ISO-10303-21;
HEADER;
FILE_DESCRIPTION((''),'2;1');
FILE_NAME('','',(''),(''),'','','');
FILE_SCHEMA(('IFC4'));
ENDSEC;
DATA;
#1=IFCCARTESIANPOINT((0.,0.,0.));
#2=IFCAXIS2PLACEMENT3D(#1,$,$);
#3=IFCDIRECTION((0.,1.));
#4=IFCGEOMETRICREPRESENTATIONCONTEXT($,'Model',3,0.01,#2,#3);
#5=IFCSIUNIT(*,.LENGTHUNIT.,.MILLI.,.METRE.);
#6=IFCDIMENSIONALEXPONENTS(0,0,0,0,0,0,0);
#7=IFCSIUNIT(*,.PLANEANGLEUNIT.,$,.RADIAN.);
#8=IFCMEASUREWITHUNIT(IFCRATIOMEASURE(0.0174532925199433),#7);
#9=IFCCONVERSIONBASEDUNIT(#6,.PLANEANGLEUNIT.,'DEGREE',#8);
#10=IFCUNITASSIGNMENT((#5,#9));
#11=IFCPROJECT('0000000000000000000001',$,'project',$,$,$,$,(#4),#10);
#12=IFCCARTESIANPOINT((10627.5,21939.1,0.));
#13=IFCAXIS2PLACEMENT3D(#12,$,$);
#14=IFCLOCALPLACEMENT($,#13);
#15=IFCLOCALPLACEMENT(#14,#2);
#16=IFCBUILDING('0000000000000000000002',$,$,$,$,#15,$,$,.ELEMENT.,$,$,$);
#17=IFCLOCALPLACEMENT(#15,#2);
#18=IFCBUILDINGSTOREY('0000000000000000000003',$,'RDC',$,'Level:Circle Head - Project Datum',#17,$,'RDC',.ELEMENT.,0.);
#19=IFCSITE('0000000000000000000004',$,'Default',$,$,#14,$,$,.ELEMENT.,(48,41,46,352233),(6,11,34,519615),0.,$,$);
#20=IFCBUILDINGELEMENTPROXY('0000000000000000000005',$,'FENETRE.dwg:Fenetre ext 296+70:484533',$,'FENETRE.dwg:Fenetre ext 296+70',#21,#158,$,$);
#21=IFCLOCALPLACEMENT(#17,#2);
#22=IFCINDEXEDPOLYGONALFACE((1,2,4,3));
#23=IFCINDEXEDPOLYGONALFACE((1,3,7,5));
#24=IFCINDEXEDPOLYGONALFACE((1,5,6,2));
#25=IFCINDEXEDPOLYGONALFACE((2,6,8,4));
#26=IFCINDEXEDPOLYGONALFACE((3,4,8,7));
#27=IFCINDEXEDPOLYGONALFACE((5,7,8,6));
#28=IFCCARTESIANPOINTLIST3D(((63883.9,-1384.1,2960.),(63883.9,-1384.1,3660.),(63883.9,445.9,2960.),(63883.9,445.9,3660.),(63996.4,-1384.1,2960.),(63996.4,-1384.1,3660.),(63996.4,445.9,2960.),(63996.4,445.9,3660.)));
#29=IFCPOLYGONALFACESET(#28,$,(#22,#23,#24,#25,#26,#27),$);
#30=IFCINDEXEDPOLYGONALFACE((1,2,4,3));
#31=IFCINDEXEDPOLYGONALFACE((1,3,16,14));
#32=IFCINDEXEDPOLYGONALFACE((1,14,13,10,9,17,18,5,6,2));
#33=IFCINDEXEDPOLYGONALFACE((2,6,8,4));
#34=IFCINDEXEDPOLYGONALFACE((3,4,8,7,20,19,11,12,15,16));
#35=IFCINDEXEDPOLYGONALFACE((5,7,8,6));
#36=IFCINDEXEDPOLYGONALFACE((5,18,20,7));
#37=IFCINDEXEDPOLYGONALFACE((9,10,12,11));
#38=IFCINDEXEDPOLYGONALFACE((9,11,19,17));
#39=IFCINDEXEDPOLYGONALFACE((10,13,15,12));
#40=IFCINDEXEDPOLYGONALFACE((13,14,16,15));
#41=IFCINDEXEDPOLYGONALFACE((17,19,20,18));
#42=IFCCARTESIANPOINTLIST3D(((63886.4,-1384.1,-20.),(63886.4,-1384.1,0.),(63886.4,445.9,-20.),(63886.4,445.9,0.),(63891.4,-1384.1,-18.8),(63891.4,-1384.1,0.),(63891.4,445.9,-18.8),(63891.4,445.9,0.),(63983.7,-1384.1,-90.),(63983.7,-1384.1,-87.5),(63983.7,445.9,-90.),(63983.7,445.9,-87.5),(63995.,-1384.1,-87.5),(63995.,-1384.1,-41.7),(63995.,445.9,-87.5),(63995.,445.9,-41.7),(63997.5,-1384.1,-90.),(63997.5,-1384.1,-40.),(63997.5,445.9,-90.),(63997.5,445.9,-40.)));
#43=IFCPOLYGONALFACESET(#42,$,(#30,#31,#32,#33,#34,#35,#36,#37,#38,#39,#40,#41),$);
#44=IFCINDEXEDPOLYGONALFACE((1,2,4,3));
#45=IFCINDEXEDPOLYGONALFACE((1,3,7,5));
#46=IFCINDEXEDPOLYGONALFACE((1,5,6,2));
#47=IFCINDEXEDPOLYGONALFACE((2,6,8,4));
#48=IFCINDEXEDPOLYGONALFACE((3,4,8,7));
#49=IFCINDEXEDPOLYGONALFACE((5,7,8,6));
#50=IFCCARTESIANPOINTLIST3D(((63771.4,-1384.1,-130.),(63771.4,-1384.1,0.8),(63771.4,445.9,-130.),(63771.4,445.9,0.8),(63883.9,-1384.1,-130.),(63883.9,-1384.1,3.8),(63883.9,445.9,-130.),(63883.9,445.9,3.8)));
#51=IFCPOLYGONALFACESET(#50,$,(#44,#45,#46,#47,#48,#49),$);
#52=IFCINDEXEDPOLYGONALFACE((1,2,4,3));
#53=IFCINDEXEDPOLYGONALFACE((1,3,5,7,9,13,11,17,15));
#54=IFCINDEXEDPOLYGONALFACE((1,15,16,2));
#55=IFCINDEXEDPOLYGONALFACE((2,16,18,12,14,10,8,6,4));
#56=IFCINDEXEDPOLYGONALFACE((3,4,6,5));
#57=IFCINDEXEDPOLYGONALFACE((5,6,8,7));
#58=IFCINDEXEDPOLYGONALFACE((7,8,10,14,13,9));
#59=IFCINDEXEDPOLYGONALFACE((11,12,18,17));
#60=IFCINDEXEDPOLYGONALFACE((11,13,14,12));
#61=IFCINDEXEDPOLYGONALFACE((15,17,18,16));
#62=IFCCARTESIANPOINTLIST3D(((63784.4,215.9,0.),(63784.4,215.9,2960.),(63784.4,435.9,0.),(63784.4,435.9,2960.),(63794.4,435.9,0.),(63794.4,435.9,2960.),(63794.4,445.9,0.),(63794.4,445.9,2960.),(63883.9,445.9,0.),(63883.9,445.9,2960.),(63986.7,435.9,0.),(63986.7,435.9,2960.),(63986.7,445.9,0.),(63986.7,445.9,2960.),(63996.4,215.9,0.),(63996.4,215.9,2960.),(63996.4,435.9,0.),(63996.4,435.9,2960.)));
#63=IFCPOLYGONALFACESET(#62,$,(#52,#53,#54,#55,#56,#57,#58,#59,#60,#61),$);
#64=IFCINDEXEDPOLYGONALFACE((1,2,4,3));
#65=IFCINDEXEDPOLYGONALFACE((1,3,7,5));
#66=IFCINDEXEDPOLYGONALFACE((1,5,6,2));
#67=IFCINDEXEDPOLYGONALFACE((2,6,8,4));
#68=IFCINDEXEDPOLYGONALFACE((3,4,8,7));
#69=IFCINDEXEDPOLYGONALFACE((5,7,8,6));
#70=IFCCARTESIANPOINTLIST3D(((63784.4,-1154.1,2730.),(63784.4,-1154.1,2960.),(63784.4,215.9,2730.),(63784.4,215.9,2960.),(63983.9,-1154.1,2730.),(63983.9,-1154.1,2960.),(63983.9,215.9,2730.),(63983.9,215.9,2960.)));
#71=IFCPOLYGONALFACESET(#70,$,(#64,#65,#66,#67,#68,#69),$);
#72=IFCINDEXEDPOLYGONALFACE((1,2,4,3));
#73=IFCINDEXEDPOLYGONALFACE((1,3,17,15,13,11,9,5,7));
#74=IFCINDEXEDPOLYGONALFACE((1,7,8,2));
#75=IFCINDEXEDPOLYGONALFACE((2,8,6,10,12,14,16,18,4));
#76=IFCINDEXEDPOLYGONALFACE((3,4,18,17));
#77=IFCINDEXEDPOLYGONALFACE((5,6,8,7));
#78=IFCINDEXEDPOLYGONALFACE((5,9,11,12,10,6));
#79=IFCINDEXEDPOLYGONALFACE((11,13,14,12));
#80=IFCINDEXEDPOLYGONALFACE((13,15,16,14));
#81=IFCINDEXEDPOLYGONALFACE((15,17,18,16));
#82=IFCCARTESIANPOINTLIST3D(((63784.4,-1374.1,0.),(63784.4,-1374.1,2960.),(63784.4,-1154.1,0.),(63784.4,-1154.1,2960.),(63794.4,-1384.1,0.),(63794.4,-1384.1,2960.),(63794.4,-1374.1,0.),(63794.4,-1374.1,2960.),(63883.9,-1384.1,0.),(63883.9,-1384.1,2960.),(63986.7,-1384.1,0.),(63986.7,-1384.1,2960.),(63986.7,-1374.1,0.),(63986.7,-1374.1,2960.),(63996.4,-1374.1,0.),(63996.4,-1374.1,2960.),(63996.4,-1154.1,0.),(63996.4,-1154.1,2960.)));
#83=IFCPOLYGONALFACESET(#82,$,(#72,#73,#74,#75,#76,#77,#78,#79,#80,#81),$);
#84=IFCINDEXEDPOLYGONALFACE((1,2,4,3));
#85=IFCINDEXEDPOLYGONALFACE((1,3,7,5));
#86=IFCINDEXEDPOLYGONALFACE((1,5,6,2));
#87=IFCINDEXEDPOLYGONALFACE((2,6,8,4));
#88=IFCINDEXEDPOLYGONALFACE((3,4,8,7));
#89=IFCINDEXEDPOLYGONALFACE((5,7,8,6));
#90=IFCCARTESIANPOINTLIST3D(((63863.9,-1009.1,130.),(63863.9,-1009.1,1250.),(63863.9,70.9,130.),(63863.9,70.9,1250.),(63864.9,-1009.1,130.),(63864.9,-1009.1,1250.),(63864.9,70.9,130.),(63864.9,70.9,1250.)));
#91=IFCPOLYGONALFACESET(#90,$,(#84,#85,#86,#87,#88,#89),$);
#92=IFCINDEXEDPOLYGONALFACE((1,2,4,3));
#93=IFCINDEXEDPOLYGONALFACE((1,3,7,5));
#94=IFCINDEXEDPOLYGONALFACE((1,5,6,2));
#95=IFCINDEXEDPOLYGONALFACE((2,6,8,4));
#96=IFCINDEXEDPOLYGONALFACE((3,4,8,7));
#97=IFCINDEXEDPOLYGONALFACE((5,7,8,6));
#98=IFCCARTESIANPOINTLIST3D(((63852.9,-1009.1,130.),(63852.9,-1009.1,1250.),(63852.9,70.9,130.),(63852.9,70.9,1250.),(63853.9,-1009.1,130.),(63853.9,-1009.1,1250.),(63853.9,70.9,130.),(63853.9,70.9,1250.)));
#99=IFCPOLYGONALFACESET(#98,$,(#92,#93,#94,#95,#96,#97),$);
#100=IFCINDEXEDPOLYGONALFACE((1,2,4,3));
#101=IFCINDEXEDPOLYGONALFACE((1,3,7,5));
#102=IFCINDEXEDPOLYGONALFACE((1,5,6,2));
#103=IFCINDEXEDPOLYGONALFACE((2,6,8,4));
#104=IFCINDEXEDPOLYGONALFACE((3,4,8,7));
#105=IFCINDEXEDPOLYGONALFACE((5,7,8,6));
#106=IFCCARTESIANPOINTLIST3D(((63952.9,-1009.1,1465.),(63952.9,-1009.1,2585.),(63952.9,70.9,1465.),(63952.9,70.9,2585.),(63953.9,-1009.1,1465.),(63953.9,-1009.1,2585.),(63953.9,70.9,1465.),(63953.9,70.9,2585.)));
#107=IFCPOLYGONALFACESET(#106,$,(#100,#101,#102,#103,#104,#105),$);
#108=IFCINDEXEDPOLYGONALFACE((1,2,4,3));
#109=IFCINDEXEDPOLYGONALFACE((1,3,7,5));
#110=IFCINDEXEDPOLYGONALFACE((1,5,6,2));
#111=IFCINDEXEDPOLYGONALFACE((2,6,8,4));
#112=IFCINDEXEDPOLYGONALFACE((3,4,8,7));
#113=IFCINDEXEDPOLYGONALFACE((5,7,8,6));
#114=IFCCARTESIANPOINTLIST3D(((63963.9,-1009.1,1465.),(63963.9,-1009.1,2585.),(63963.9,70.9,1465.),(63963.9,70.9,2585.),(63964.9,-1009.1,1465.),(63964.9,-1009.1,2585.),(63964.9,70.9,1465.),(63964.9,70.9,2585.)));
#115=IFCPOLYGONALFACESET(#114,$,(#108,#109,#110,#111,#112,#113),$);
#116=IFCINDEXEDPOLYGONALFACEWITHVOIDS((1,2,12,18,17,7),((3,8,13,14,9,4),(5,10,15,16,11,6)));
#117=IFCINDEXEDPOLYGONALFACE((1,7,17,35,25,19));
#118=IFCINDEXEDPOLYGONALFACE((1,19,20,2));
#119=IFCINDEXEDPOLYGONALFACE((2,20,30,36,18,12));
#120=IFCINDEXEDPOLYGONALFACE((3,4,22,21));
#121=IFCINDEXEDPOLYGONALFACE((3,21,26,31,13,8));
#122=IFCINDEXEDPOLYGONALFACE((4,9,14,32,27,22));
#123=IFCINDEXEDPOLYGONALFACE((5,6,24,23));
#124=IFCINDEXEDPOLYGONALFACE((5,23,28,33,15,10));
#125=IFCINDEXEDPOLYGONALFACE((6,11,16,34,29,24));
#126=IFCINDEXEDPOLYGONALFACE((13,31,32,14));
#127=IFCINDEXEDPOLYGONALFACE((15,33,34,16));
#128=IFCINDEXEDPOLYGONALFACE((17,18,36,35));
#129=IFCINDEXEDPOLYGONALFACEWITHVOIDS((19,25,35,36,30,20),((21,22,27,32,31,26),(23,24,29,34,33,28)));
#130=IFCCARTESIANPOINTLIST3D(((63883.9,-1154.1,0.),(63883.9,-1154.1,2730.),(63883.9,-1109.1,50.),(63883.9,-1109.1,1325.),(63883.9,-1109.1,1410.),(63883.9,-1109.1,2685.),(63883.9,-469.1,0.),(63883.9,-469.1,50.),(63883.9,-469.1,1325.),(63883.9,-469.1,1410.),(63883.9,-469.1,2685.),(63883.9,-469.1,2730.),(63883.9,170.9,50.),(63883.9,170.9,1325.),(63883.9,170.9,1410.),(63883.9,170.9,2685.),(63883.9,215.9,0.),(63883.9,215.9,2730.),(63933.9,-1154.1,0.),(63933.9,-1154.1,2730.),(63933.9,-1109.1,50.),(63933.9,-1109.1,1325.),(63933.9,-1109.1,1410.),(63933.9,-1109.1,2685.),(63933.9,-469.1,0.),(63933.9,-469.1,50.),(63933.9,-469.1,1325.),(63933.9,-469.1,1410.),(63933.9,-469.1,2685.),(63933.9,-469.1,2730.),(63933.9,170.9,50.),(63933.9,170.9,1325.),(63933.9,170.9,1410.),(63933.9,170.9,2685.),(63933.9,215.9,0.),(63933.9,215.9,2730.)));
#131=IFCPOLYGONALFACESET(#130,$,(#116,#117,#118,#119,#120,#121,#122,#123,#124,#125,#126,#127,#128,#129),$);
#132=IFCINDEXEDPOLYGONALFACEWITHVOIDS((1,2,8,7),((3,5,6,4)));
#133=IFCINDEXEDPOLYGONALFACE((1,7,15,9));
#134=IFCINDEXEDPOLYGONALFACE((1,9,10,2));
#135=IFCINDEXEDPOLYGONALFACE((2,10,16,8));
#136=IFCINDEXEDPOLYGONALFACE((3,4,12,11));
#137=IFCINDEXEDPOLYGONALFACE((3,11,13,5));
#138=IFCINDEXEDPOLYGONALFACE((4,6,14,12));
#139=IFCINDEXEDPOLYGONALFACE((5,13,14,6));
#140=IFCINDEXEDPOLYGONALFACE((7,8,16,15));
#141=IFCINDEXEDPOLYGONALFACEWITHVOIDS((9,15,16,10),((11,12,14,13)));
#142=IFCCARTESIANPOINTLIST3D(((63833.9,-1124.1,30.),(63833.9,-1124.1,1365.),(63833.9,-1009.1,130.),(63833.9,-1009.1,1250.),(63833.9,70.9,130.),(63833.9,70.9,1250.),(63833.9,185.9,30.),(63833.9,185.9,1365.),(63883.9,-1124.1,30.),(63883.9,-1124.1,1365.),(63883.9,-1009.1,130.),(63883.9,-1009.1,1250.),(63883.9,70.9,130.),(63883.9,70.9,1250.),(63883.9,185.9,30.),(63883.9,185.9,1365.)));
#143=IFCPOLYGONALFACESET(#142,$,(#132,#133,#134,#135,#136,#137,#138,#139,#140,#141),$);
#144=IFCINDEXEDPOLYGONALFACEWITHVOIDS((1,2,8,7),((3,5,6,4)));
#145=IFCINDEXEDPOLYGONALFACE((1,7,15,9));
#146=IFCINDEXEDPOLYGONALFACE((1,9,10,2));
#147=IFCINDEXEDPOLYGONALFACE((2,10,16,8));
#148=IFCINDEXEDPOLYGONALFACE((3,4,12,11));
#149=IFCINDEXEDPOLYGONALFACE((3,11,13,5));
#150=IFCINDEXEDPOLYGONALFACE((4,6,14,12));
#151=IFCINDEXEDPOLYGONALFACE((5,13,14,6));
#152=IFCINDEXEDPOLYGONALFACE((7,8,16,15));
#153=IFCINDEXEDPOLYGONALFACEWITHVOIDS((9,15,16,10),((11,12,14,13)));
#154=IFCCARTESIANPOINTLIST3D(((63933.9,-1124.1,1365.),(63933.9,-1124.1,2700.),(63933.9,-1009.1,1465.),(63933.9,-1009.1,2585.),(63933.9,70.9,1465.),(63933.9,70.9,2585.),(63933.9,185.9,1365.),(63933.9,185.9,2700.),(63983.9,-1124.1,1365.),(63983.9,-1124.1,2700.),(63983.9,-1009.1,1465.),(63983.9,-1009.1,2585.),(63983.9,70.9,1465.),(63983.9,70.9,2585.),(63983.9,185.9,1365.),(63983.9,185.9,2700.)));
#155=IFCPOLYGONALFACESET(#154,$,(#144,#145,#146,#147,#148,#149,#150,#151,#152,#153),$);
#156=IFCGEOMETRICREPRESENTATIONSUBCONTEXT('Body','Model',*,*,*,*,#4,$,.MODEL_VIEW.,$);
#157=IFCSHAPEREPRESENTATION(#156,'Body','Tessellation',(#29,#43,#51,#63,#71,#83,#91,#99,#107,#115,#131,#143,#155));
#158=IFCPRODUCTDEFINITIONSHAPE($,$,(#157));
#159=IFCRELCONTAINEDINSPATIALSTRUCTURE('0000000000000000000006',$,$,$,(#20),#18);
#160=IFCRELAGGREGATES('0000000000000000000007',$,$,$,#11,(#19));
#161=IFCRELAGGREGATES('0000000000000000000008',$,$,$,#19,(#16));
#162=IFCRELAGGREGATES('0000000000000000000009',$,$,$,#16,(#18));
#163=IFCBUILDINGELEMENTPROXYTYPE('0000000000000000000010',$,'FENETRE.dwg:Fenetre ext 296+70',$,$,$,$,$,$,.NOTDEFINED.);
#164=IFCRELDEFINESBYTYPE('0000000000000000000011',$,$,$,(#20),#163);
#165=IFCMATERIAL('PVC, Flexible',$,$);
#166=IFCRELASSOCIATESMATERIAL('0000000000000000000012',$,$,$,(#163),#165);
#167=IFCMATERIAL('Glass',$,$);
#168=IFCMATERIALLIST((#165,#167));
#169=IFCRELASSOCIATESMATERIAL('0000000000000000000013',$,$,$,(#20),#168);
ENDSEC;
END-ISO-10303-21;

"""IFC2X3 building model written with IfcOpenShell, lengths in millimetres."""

from ifc_helpers import new_model, entity, si_unit, converted_unit, direction, frame, frame_2d, origin, origin_2d_with_axis, place, context, subcontext, project, spatial, polyline, rectangle, outline, extrude, source, transform, mapped, material, material_list, type_object, type_shapes, element, save


model = new_model("IFC2X3")

# Units and contexts
model_context = context("Model", 3, precision=0.01, world=origin(), true_north=direction((0.0, 1.0)))
body_context = subcontext(model_context, "Body", "Model", "MODEL_VIEW")
ifc_project = project(units=[si_unit("LENGTHUNIT", "METRE", prefix="MILLI"), converted_unit("PLANEANGLEUNIT", "DEGREE", entity("IfcRatioMeasure", 0.0174532925199433), si_unit("PLANEANGLEUNIT", "RADIAN"), dimensions=[0, 0, 0, 0, 0, 0, 0])], contexts=[model_context])

# Site, building, storey
site_placement = place(None, frame((10627.5, 21939.1, 0.0)))
site = spatial("IfcSite", under=ifc_project, at=site_placement, Name="Default", CompositionType="ELEMENT", RefLatitude=(48, 41, 46, 352233), RefLongitude=(6, 11, 34, 519615), RefElevation=0.0)
building_placement = place(site_placement, origin())
building = spatial("IfcBuilding", under=site, at=building_placement, CompositionType="ELEMENT")
storey_placement = place(building_placement, origin())
storey = spatial("IfcBuildingStorey", under=building, at=storey_placement, Name="RDC", ObjectType="Level:Circle Head - Project Datum", LongName="RDC", CompositionType="ELEMENT", Elevation=0.0)

# Building element proxy
ifc_material_1 = material(Name="PVC, Flexible")
ifc_material_2 = material(Name="Glass")
building_element_proxy_type_1 = type_object("IfcBuildingElementProxyType", Name="FENETRE.dwg:Fenetre ext 296+70", PredefinedType="NOTDEFINED", material=ifc_material_1)
shared_shape_1 = source(origin(), body_context, "Body", "SweptSolid", [
    extrude(rectangle(XDim=112.5, YDim=1830.0, at=origin_2d_with_axis()), frame((-10.4, -56.3, 2960.0), z_axis=(0.0, 0.0, 1.0), x_axis=(0.0, 1.0, 0.0)), (0.0, 0.0, 1.0), 700.0),
    extrude(outline(polyline([(27.5, -64.4), (47.5, -64.4), (47.5, -59.4), (28.8, -59.4), (7.5, 46.7), (-42.5, 46.7), (-42.5, 32.9), (-40.0, 32.9), (-40.0, 44.2), (5.8, 44.2), (27.5, -64.4)])), frame((-925.4, -66.9, -47.5), z_axis=(1.0, 0.0, 0.0), x_axis=(0.0, 0.0, 1.0)), (0.0, 0.0, 1.0), 1830.0),
    extrude(outline(polyline([(-54.5, -66.1), (58.0, -66.1), (54.5, 67.6), (-58.0, 64.6), (-54.5, -66.1)])), frame((-925.4, 56.3, -63.8), z_axis=(1.0, 0.0, 0.0), x_axis=(0.0, -0.999645, 0.02665)), (0.0, 0.0, 1.0), 1830.0),
    extrude(outline(polyline([(-97.0, -55.6), (5.9, -55.6), (95.4, -55.6), (95.4, -45.6), (105.4, -45.6), (105.4, 174.4), (-106.6, 174.4), (-106.6, -45.6), (-97.0, -45.6), (-97.0, -55.6)])), frame((849.0, -5.9, 0.0), z_axis=(0.0, 0.0, 1.0), x_axis=(0.0, 1.0, 0.0)), (0.0, 0.0, 1.0), 2960.0),
    extrude(rectangle(XDim=1370.0, YDim=199.5, at=origin_2d_with_axis()), frame((-10.4, -0.3, 2730.0), z_axis=(0.0, 0.0, 1.0), x_axis=(-1.0, 0.0, 0.0)), (0.0, 0.0, 1.0), 230.0),
    extrude(outline(polyline([(-55.6, 97.0), (-55.6, -5.9), (-55.6, -95.4), (-45.6, -95.4), (-45.6, -105.4), (174.4, -105.4), (174.4, 106.6), (-45.6, 106.6), (-45.6, 97.0), (-55.6, 97.0)])), frame((-869.9, -5.9, 0.0), z_axis=(0.0, 0.0, -1.0), x_axis=(1.0, 0.0, 0.0)), (0.0, 0.0, -1.0), 2960.0),
    extrude(rectangle(XDim=1080.0, YDim=1.0, at=origin_2d_with_axis()), frame((-10.4, 19.5, 130.0), z_axis=(0.0, 0.0, 1.0), x_axis=(-1.0, 0.0, 0.0)), (0.0, 0.0, 1.0), 1120.0),
    extrude(rectangle(XDim=1080.0, YDim=1.0, at=origin_2d_with_axis()), frame((-10.4, 30.5, 130.0), z_axis=(0.0, 0.0, 1.0), x_axis=(-1.0, 0.0, 0.0)), (0.0, 0.0, 1.0), 1120.0),
    extrude(rectangle(XDim=1080.0, YDim=1.0, at=frame_2d((0.0, 0.0), x_axis=(1.0, 0.0))), frame((-10.4, -69.5, 1465.0), z_axis=(0.0, 0.0, 1.0), x_axis=(-1.0, 0.0, 0.0)), (0.0, 0.0, 1.0), 1120.0),
    extrude(rectangle(XDim=1080.0, YDim=1.0, at=frame_2d((0.0, 0.0), x_axis=(1.0, 0.0))), frame((-10.4, -80.5, 1465.0), z_axis=(0.0, 0.0, 1.0), x_axis=(-1.0, 0.0, 0.0)), (0.0, 0.0, 1.0), 1120.0),
    extrude(outline(polyline([(-685.0, -1365.0), (0.0, -1365.0), (685.0, -1365.0), (685.0, 1365.0), (0.0, 1365.0), (-685.0, 1365.0), (-685.0, -1365.0)]), holes=[polyline([(-640.0, -1320.0), (-640.0, -45.0), (0.0, -45.0), (640.0, -45.0), (640.0, -1320.0), (0.0, -1320.0), (-640.0, -1320.0)]), polyline([(-640.0, 40.0), (-640.0, 1315.0), (0.0, 1315.0), (640.0, 1315.0), (640.0, 40.0), (0.0, 40.0), (-640.0, 40.0)])]), frame((-10.4, -50.0, 1365.0), z_axis=(0.0, 1.0, 0.0), x_axis=(1.0, 0.0, 0.0)), (0.0, 0.0, 1.0), 50.0),
    extrude(outline(polyline([(-655.0, -667.5), (655.0, -667.5), (655.0, 667.5), (-655.0, 667.5), (-655.0, -667.5)]), holes=[polyline([(-540.0, 552.5), (540.0, 552.5), (540.0, -567.5), (-540.0, -567.5), (-540.0, 552.5)])]), frame((-10.4, 0.0, 697.5), z_axis=(0.0, 1.0, 0.0), x_axis=(-1.0, 0.0, 0.0)), (0.0, 0.0, 1.0), 50.0),
    extrude(outline(polyline([(-655.0, -667.5), (655.0, -667.5), (655.0, 667.5), (-655.0, 667.5), (-655.0, -667.5)]), holes=[polyline([(-540.0, 552.5), (540.0, 552.5), (540.0, -567.5), (-540.0, -567.5), (-540.0, 552.5)])]), frame((-10.4, -100.0, 2032.5), z_axis=(0.0, 1.0, 0.0), x_axis=(-1.0, 0.0, 0.0)), (0.0, 0.0, 1.0), 50.0),
])
type_shapes(building_element_proxy_type_1, [shared_shape_1])
ifc_material_list_1 = material_list([ifc_material_1, ifc_material_2])
proxy_1_placement = place(storey_placement, frame((63883.9, -458.7, 0.0), z_axis=(0.0, 0.0, 1.0), x_axis=(0.0, 1.0, 0.0)))
element("IfcBuildingElementProxy", 1, at=proxy_1_placement, inside=storey, type_object=building_element_proxy_type_1, material=ifc_material_list_1, Name="FENETRE.dwg:Fenetre ext 296+70:484533", ObjectType="FENETRE.dwg:Fenetre ext 296+70", context=body_context, shape_type="MappedRepresentation", body=[
    mapped(shared_shape_1, transform((0.0, 0.0, 0.0), scale=1.0)),
])

save(model, "model.ifc")
